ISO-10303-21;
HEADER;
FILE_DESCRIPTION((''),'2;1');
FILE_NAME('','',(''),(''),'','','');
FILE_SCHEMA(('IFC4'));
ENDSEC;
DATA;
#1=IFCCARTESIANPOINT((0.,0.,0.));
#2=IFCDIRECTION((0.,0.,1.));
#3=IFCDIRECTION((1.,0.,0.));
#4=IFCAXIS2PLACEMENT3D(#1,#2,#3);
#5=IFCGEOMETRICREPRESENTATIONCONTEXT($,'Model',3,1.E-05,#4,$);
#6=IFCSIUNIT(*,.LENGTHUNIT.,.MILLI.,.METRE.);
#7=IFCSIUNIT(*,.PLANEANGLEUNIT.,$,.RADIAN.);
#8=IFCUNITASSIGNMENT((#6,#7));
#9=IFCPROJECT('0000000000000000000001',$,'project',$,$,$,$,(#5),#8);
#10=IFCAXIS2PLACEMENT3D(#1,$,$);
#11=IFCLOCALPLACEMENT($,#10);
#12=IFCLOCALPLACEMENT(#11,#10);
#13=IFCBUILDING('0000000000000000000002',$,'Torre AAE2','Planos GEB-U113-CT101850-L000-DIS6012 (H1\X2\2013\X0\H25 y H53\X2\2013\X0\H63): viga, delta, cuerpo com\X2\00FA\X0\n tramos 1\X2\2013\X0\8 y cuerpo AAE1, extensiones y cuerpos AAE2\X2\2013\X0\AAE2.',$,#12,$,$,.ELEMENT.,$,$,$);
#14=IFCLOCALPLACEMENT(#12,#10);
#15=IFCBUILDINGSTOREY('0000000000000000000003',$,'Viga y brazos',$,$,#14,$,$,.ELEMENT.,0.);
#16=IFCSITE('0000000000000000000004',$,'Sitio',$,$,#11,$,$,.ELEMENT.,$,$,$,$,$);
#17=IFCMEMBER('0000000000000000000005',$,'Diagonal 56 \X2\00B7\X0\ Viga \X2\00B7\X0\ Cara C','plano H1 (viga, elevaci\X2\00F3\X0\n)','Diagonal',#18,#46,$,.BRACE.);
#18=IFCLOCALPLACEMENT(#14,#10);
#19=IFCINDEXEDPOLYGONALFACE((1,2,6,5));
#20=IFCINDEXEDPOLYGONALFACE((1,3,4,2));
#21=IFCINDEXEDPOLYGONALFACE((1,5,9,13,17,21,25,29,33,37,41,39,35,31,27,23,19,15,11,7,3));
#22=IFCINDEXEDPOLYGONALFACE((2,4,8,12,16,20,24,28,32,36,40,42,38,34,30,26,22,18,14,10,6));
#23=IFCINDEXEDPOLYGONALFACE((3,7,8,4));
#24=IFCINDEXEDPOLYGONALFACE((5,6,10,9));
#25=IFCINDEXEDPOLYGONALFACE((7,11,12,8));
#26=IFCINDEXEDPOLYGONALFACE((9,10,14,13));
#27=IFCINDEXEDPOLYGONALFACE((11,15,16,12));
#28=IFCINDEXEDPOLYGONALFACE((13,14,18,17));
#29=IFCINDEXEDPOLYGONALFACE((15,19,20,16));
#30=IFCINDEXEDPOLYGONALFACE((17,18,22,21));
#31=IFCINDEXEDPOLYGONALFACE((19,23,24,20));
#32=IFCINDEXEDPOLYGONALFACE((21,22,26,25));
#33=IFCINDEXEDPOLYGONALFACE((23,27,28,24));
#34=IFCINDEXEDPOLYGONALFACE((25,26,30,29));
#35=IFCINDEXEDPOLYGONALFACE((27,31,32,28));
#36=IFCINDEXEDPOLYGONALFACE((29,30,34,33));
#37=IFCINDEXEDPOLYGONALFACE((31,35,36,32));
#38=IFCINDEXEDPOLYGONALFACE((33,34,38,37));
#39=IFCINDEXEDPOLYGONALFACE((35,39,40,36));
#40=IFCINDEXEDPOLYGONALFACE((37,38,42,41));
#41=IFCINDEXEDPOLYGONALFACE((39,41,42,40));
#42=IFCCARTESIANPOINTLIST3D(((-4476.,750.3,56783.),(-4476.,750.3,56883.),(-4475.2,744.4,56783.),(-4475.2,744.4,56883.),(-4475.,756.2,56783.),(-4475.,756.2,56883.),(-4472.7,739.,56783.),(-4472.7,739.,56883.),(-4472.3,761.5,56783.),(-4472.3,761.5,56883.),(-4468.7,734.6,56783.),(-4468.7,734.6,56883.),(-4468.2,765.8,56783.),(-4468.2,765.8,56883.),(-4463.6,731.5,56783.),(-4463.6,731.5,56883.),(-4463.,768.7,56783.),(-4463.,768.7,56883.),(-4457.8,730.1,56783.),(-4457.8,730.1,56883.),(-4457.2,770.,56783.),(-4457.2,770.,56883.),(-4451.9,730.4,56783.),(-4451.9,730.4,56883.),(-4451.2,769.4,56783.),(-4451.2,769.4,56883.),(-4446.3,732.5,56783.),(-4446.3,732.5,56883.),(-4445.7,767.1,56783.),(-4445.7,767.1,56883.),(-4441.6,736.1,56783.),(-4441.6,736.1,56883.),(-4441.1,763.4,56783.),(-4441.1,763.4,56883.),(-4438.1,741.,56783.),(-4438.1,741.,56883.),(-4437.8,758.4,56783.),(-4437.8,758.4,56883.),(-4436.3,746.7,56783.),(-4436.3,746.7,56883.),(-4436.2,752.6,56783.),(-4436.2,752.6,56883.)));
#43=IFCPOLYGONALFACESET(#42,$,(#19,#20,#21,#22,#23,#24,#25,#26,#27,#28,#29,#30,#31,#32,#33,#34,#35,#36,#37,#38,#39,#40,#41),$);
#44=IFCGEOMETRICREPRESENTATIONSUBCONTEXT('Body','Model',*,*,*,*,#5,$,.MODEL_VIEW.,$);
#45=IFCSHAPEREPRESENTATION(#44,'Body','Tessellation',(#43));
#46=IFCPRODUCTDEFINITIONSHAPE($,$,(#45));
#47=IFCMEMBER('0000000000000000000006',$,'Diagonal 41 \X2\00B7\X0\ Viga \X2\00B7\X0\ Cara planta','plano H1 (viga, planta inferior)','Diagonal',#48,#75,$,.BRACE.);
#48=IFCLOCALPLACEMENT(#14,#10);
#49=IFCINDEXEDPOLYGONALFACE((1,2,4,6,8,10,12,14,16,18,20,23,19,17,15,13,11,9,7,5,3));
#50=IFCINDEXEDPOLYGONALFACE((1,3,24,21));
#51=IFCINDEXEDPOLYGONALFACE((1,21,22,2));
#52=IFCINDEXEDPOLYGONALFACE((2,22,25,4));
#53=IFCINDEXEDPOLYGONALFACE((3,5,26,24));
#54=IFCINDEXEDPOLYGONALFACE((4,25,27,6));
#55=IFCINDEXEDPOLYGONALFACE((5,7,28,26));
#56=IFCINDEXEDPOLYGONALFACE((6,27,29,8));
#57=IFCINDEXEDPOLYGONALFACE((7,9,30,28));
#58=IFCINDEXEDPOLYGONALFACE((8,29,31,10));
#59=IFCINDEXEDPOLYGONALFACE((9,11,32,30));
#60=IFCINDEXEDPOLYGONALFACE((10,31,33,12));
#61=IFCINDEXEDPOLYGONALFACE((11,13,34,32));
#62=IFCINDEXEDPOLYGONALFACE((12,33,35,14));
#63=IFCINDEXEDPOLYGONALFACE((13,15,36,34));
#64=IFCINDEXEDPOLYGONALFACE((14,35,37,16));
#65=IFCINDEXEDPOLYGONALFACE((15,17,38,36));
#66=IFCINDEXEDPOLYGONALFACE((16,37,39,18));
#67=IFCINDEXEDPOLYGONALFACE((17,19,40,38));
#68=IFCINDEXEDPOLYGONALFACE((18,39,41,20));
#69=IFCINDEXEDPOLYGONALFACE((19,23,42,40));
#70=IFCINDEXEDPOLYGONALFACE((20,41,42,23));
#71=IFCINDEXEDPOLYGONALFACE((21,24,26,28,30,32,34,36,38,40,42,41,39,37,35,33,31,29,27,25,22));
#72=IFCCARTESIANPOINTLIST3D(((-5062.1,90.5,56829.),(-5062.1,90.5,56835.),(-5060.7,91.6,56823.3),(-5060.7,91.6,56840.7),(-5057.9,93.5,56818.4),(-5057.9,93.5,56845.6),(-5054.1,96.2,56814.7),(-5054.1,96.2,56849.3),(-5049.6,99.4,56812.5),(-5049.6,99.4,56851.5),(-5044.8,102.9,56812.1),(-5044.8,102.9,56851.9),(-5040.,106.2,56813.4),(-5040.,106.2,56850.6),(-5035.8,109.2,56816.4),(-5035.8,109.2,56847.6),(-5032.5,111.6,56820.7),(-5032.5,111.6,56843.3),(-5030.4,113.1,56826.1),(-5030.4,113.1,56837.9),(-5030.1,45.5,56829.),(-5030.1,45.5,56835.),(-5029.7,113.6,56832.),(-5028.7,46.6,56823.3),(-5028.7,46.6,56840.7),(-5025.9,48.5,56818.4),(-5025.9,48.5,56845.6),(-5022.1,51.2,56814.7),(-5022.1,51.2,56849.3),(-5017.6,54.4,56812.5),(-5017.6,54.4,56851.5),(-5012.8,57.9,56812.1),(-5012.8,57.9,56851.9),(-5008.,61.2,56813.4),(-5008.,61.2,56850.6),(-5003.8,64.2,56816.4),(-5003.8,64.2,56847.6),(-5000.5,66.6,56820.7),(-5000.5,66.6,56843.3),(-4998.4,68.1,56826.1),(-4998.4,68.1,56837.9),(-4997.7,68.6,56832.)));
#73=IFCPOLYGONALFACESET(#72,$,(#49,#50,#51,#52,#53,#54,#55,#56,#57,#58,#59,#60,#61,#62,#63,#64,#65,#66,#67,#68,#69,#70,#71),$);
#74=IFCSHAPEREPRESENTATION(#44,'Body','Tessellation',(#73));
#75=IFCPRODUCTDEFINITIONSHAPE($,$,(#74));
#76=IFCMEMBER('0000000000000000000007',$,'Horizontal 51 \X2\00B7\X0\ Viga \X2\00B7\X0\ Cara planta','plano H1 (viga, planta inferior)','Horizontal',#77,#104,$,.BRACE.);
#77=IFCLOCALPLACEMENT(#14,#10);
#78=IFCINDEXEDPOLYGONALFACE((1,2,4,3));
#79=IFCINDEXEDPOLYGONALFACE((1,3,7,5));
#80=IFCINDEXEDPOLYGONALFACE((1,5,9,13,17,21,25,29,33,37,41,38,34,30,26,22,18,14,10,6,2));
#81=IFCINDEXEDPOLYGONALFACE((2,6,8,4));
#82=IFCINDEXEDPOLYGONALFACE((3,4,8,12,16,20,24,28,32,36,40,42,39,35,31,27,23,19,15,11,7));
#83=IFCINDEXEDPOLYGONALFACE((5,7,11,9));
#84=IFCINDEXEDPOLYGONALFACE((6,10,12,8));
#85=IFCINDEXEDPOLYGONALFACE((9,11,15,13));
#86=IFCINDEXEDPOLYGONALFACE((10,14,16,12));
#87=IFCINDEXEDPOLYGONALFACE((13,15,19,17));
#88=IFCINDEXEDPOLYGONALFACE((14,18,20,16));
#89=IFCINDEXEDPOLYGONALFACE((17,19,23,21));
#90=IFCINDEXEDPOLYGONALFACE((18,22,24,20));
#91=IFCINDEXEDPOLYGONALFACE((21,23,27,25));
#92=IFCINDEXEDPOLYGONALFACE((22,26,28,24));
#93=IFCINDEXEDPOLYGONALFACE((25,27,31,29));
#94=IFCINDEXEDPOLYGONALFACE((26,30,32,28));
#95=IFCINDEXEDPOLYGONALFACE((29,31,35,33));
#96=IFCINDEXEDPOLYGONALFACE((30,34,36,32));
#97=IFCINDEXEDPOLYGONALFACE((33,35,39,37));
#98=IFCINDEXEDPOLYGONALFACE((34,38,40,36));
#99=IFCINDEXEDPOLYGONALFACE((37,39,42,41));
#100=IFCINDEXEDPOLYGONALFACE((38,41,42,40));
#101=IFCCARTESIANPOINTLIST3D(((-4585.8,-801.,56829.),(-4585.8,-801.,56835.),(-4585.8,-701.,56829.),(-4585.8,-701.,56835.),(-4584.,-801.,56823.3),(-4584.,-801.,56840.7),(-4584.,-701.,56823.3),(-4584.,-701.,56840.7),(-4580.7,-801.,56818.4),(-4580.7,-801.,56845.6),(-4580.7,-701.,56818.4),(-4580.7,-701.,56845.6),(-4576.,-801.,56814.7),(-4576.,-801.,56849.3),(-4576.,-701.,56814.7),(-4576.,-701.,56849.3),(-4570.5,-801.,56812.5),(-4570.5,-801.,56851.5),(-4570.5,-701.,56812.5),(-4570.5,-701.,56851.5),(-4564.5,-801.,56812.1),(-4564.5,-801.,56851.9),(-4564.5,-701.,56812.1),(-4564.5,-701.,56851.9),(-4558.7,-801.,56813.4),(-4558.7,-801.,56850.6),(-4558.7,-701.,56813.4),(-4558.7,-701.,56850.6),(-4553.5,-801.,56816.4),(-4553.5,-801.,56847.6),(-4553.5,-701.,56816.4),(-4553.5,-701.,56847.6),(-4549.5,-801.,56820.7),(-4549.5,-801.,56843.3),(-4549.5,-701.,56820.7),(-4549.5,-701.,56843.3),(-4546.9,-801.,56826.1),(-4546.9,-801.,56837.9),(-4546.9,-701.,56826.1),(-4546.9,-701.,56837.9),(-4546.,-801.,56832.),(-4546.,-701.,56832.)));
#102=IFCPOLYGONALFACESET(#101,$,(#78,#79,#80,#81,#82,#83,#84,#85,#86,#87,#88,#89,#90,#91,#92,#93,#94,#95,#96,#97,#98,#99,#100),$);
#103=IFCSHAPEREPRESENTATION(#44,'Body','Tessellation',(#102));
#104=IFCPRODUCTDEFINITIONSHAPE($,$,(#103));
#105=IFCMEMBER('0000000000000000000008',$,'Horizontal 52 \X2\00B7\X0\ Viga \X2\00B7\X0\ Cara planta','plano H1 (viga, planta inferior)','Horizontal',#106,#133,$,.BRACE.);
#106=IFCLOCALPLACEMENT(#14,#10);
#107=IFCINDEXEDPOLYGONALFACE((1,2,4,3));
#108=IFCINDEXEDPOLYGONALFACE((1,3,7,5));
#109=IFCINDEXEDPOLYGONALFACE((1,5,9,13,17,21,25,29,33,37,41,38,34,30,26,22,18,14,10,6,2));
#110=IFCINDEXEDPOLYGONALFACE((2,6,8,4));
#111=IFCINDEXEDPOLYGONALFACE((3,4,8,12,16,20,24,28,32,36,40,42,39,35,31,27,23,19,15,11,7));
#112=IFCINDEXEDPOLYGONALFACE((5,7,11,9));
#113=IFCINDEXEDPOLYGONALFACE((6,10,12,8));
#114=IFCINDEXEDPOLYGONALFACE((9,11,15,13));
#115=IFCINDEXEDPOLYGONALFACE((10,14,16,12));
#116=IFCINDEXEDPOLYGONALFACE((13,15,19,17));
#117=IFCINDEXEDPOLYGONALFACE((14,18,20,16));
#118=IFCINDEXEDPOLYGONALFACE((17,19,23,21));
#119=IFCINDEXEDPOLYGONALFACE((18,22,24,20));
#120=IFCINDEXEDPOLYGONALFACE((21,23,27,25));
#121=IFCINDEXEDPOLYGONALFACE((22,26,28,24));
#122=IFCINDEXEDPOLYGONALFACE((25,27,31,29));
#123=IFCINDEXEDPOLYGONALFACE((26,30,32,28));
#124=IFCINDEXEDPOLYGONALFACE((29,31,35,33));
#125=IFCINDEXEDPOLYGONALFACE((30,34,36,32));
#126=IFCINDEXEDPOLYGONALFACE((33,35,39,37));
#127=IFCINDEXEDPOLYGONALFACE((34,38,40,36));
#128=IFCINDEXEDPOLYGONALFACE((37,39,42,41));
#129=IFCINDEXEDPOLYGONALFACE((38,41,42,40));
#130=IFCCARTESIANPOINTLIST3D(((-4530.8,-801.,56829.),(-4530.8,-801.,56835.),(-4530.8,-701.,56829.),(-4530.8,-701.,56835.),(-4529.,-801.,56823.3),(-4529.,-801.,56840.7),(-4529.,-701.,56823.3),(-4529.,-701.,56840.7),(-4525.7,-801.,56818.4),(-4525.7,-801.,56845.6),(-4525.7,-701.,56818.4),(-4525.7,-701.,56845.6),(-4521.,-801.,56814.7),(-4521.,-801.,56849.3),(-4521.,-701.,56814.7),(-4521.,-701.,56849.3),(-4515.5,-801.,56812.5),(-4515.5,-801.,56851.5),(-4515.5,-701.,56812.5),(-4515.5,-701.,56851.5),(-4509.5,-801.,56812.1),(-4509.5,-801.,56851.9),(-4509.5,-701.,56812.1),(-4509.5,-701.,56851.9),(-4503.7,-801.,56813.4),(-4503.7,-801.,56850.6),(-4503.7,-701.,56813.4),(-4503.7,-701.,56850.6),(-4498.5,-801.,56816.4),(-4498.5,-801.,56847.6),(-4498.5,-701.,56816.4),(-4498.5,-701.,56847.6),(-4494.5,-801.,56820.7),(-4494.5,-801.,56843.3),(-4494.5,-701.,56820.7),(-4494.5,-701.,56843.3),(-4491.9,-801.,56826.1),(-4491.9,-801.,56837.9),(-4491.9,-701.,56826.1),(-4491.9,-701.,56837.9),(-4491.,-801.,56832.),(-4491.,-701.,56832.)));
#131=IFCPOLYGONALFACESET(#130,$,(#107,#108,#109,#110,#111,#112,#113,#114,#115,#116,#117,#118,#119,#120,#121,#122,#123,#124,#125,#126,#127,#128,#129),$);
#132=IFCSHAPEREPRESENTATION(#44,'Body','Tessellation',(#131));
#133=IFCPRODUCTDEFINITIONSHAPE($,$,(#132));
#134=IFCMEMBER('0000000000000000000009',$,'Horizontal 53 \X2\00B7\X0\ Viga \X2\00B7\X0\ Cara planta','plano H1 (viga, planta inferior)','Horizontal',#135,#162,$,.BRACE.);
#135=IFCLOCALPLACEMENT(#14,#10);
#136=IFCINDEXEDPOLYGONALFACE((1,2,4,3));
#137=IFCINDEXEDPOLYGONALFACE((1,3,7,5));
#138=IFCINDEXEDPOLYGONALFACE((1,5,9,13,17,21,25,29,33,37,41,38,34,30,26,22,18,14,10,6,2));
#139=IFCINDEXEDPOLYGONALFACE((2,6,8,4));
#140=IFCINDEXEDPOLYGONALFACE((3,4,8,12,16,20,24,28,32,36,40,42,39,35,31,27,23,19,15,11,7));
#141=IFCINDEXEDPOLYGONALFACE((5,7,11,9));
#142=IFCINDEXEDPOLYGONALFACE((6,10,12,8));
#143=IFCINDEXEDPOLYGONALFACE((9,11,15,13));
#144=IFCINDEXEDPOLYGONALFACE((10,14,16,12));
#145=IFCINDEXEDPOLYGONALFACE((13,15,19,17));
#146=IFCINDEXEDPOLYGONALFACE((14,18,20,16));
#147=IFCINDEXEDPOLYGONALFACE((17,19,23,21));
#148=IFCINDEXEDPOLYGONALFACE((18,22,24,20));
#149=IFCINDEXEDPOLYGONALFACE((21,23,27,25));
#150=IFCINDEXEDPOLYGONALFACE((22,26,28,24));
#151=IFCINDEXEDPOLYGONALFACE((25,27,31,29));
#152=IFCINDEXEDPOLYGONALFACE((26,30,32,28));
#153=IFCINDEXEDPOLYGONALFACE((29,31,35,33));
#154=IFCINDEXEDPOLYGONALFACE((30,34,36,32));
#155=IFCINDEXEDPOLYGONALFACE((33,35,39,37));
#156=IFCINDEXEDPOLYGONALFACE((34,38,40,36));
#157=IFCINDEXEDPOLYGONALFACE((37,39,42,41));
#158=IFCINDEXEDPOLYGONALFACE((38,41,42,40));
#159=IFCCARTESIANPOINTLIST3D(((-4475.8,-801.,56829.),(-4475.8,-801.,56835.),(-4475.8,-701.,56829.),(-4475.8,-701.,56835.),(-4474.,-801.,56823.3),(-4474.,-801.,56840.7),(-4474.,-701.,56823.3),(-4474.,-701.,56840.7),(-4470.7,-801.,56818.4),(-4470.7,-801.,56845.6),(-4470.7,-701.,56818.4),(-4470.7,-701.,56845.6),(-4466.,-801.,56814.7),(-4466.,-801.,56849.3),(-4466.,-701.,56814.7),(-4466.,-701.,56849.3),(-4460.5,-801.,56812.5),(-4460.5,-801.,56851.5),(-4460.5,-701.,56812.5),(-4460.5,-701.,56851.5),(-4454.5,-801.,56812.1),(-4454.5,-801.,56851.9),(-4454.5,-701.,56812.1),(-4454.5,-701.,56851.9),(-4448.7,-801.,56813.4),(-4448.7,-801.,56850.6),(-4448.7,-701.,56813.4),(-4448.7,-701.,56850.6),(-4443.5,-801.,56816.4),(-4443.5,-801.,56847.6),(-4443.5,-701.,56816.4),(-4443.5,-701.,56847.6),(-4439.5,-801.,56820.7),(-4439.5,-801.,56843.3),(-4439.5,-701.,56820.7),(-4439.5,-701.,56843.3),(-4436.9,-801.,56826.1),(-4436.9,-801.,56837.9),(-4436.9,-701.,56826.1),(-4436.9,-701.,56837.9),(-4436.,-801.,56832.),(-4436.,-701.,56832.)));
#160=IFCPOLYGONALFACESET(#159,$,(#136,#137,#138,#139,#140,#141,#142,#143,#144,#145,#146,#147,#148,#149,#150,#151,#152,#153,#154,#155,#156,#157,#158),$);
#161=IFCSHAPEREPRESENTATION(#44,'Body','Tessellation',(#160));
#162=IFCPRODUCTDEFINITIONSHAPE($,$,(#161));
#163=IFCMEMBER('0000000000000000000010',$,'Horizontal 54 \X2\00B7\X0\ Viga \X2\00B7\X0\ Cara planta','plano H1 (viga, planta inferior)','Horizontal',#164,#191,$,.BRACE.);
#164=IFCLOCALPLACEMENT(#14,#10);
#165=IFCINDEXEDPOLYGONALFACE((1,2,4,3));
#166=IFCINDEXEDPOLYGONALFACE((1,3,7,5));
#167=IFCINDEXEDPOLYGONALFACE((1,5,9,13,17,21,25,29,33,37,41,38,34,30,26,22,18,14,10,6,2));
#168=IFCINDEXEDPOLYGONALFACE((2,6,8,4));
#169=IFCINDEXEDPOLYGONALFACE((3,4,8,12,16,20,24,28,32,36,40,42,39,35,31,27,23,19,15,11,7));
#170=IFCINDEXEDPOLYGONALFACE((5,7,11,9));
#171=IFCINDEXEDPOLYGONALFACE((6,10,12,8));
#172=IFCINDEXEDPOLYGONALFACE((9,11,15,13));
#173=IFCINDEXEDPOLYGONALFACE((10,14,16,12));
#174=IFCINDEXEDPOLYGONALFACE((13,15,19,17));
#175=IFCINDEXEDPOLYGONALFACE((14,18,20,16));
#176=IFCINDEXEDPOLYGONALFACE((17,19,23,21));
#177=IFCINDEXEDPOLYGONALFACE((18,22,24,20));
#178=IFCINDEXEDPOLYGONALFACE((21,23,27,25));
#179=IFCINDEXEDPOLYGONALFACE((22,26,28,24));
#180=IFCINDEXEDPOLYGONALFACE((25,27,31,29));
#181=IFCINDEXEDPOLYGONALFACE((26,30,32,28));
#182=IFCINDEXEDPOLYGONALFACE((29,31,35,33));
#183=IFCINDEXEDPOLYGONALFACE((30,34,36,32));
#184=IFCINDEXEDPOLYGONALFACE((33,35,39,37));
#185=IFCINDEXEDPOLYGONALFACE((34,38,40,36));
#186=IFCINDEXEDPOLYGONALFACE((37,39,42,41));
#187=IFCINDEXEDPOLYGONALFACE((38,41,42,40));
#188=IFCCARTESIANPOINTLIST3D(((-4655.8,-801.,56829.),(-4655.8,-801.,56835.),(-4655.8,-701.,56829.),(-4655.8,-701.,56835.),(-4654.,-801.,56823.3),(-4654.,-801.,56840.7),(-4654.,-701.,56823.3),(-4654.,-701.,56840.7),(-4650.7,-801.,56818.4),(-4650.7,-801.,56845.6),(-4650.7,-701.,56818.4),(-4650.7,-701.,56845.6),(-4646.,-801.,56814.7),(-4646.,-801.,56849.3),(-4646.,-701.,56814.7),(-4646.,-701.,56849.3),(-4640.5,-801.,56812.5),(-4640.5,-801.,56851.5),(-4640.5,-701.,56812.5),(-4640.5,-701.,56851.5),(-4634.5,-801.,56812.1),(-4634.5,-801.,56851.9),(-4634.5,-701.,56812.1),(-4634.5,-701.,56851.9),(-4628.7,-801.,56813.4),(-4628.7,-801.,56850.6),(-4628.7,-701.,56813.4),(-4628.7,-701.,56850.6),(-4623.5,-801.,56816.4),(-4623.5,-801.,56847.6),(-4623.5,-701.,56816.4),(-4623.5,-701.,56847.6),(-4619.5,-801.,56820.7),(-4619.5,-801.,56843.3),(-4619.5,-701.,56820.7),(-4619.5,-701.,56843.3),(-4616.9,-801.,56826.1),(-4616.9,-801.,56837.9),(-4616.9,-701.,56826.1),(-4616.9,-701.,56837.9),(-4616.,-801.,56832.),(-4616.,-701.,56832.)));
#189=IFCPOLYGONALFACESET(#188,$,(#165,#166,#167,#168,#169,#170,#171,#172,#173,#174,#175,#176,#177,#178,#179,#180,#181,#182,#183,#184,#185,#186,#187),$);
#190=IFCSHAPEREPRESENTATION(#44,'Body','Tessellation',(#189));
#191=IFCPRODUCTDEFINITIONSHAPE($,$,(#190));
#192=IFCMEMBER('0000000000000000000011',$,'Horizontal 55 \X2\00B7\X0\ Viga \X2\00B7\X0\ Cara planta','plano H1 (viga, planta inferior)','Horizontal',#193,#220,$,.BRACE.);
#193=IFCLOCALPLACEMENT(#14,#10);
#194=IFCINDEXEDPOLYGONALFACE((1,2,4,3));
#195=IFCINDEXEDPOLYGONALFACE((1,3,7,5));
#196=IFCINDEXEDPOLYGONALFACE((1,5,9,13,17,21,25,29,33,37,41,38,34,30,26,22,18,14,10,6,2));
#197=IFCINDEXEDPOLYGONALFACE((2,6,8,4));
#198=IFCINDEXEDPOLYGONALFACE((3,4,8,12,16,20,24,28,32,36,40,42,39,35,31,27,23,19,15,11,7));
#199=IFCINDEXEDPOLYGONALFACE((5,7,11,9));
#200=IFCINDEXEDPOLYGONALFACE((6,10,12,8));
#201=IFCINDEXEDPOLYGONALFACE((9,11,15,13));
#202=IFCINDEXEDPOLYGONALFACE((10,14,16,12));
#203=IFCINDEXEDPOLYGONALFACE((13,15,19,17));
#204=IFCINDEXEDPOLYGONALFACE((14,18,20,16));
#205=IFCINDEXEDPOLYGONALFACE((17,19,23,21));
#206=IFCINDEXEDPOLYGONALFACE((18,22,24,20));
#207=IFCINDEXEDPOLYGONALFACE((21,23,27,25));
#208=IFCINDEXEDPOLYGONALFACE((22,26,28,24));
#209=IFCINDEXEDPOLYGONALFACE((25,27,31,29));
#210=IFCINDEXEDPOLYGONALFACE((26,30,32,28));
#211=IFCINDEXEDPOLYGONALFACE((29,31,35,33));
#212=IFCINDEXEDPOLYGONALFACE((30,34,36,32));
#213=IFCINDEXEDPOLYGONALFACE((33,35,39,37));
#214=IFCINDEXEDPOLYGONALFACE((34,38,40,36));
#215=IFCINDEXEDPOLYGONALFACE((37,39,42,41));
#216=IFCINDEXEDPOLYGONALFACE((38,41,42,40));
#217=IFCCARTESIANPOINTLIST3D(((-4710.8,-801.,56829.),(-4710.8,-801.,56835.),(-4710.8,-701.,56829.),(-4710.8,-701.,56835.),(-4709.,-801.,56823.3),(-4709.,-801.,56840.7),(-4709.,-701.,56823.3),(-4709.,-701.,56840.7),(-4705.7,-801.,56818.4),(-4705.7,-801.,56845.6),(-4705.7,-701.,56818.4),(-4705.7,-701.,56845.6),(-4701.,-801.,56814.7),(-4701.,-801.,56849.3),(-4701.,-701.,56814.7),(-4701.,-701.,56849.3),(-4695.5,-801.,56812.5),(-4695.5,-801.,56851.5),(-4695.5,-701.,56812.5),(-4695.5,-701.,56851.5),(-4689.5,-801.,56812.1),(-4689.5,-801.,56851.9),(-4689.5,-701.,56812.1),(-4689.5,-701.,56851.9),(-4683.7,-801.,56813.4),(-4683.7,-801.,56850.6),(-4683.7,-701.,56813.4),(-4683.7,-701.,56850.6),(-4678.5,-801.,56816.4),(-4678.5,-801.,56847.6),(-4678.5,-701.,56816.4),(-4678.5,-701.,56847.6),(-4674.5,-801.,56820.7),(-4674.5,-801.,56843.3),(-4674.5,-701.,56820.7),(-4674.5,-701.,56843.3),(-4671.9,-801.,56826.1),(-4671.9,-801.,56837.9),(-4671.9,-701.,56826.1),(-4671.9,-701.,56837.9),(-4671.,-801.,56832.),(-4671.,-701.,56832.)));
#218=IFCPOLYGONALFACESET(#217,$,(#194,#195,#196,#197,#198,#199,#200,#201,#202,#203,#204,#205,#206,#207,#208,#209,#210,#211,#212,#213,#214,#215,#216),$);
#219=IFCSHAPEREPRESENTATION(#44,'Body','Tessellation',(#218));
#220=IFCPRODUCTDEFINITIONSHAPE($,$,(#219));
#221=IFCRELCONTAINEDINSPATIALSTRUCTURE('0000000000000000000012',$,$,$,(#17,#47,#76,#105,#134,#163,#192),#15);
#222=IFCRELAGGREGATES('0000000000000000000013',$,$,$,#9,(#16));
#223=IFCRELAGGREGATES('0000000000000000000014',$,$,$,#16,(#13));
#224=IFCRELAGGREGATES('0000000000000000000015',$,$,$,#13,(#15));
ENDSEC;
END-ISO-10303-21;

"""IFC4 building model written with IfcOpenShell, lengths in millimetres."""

from ifc_helpers import new_model, si_unit, frame, origin, origin_with_axes, place, context, subcontext, project, spatial, circle, extrude, element, save


model = new_model("IFC4")

# Units and contexts
model_context = context("Model", 3, precision=1e-05, world=origin_with_axes())
body_context = subcontext(model_context, "Body", "Model", "MODEL_VIEW")
ifc_project = project(units=[si_unit("LENGTHUNIT", "METRE", prefix="MILLI"), si_unit("PLANEANGLEUNIT", "RADIAN")], contexts=[model_context])

# Site, building, storey
site_placement = place(None, origin())
site = spatial("IfcSite", under=ifc_project, at=site_placement, Name="Sitio", CompositionType="ELEMENT")
building_placement = place(site_placement, origin())
building = spatial("IfcBuilding", under=site, at=building_placement, Name="Torre AAE2", Description="Planos GEB-U113-CT101850-L000-DIS6012 (H1–H25 y H53–H63): viga, delta, cuerpo común tramos 1–8 y cuerpo AAE1, extensiones y cuerpos AAE2–AAE2.", CompositionType="ELEMENT")
storey_placement = place(building_placement, origin())
storey = spatial("IfcBuildingStorey", under=building, at=storey_placement, Name="Viga y brazos", CompositionType="ELEMENT", Elevation=0.0)

# Members
for number, where, z_axis, x_axis, name in (
    (1, (-4456.0, 750.0, 56883.0), (0.0, 0.0, -1.0), (0.986129, -0.165978, 0.0), "Diagonal 56 · Viga · Cara C"),
):
    element("IfcMember", number, at=place(storey_placement, frame(where, z_axis=z_axis, x_axis=x_axis)), inside=storey, Name=name, Description="plano H1 (viga, elevación)", ObjectType="Diagonal", PredefinedType="BRACE", context=body_context, shape_type="SweptSolid", body=[
        extrude(circle(Radius=20.0), None, (0.0, 0.0, 1.0), 100.0),
    ])
member_placement = place(storey_placement, frame((-5046.0, 102.0, 56832.0), z_axis=(0.579524, -0.814955, 0.0), x_axis=(0.814955, 0.579524, 0.0)))
element("IfcMember", 2, at=member_placement, inside=storey, Name="Diagonal 41 · Viga · Cara planta", Description="plano H1 (viga, planta inferior)", ObjectType="Diagonal", PredefinedType="BRACE", context=body_context, shape_type="SweptSolid", body=[
    extrude(circle(Radius=20.0), None, (0.0, 0.0, 1.0), 55.2),
])
for number, where, z_axis, x_axis, name in (
    (3, (-4566.0, -701.0, 56832.0), (0.0, -1.0, 0.0), (1.0, 0.0, 0.0), "Horizontal 51 · Viga · Cara planta"),
    (4, (-4511.0, -701.0, 56832.0), (0.0, -1.0, 0.0), (1.0, 0.0, 0.0), "Horizontal 52 · Viga · Cara planta"),
    (5, (-4456.0, -701.0, 56832.0), (0.0, -1.0, 0.0), (1.0, 0.0, 0.0), "Horizontal 53 · Viga · Cara planta"),
    (6, (-4636.0, -701.0, 56832.0), (0.0, -1.0, 0.0), (1.0, 0.0, 0.0), "Horizontal 54 · Viga · Cara planta"),
    (7, (-4691.0, -701.0, 56832.0), (0.0, -1.0, 0.0), (1.0, 0.0, 0.0), "Horizontal 55 · Viga · Cara planta"),
):
    element("IfcMember", number, at=place(storey_placement, frame(where, z_axis=z_axis, x_axis=x_axis)), inside=storey, Name=name, Description="plano H1 (viga, planta inferior)", ObjectType="Horizontal", PredefinedType="BRACE", context=body_context, shape_type="SweptSolid", body=[
        extrude(circle(Radius=20.0), None, (0.0, 0.0, 1.0), 100.0),
    ])

save(model, "model.ifc")
